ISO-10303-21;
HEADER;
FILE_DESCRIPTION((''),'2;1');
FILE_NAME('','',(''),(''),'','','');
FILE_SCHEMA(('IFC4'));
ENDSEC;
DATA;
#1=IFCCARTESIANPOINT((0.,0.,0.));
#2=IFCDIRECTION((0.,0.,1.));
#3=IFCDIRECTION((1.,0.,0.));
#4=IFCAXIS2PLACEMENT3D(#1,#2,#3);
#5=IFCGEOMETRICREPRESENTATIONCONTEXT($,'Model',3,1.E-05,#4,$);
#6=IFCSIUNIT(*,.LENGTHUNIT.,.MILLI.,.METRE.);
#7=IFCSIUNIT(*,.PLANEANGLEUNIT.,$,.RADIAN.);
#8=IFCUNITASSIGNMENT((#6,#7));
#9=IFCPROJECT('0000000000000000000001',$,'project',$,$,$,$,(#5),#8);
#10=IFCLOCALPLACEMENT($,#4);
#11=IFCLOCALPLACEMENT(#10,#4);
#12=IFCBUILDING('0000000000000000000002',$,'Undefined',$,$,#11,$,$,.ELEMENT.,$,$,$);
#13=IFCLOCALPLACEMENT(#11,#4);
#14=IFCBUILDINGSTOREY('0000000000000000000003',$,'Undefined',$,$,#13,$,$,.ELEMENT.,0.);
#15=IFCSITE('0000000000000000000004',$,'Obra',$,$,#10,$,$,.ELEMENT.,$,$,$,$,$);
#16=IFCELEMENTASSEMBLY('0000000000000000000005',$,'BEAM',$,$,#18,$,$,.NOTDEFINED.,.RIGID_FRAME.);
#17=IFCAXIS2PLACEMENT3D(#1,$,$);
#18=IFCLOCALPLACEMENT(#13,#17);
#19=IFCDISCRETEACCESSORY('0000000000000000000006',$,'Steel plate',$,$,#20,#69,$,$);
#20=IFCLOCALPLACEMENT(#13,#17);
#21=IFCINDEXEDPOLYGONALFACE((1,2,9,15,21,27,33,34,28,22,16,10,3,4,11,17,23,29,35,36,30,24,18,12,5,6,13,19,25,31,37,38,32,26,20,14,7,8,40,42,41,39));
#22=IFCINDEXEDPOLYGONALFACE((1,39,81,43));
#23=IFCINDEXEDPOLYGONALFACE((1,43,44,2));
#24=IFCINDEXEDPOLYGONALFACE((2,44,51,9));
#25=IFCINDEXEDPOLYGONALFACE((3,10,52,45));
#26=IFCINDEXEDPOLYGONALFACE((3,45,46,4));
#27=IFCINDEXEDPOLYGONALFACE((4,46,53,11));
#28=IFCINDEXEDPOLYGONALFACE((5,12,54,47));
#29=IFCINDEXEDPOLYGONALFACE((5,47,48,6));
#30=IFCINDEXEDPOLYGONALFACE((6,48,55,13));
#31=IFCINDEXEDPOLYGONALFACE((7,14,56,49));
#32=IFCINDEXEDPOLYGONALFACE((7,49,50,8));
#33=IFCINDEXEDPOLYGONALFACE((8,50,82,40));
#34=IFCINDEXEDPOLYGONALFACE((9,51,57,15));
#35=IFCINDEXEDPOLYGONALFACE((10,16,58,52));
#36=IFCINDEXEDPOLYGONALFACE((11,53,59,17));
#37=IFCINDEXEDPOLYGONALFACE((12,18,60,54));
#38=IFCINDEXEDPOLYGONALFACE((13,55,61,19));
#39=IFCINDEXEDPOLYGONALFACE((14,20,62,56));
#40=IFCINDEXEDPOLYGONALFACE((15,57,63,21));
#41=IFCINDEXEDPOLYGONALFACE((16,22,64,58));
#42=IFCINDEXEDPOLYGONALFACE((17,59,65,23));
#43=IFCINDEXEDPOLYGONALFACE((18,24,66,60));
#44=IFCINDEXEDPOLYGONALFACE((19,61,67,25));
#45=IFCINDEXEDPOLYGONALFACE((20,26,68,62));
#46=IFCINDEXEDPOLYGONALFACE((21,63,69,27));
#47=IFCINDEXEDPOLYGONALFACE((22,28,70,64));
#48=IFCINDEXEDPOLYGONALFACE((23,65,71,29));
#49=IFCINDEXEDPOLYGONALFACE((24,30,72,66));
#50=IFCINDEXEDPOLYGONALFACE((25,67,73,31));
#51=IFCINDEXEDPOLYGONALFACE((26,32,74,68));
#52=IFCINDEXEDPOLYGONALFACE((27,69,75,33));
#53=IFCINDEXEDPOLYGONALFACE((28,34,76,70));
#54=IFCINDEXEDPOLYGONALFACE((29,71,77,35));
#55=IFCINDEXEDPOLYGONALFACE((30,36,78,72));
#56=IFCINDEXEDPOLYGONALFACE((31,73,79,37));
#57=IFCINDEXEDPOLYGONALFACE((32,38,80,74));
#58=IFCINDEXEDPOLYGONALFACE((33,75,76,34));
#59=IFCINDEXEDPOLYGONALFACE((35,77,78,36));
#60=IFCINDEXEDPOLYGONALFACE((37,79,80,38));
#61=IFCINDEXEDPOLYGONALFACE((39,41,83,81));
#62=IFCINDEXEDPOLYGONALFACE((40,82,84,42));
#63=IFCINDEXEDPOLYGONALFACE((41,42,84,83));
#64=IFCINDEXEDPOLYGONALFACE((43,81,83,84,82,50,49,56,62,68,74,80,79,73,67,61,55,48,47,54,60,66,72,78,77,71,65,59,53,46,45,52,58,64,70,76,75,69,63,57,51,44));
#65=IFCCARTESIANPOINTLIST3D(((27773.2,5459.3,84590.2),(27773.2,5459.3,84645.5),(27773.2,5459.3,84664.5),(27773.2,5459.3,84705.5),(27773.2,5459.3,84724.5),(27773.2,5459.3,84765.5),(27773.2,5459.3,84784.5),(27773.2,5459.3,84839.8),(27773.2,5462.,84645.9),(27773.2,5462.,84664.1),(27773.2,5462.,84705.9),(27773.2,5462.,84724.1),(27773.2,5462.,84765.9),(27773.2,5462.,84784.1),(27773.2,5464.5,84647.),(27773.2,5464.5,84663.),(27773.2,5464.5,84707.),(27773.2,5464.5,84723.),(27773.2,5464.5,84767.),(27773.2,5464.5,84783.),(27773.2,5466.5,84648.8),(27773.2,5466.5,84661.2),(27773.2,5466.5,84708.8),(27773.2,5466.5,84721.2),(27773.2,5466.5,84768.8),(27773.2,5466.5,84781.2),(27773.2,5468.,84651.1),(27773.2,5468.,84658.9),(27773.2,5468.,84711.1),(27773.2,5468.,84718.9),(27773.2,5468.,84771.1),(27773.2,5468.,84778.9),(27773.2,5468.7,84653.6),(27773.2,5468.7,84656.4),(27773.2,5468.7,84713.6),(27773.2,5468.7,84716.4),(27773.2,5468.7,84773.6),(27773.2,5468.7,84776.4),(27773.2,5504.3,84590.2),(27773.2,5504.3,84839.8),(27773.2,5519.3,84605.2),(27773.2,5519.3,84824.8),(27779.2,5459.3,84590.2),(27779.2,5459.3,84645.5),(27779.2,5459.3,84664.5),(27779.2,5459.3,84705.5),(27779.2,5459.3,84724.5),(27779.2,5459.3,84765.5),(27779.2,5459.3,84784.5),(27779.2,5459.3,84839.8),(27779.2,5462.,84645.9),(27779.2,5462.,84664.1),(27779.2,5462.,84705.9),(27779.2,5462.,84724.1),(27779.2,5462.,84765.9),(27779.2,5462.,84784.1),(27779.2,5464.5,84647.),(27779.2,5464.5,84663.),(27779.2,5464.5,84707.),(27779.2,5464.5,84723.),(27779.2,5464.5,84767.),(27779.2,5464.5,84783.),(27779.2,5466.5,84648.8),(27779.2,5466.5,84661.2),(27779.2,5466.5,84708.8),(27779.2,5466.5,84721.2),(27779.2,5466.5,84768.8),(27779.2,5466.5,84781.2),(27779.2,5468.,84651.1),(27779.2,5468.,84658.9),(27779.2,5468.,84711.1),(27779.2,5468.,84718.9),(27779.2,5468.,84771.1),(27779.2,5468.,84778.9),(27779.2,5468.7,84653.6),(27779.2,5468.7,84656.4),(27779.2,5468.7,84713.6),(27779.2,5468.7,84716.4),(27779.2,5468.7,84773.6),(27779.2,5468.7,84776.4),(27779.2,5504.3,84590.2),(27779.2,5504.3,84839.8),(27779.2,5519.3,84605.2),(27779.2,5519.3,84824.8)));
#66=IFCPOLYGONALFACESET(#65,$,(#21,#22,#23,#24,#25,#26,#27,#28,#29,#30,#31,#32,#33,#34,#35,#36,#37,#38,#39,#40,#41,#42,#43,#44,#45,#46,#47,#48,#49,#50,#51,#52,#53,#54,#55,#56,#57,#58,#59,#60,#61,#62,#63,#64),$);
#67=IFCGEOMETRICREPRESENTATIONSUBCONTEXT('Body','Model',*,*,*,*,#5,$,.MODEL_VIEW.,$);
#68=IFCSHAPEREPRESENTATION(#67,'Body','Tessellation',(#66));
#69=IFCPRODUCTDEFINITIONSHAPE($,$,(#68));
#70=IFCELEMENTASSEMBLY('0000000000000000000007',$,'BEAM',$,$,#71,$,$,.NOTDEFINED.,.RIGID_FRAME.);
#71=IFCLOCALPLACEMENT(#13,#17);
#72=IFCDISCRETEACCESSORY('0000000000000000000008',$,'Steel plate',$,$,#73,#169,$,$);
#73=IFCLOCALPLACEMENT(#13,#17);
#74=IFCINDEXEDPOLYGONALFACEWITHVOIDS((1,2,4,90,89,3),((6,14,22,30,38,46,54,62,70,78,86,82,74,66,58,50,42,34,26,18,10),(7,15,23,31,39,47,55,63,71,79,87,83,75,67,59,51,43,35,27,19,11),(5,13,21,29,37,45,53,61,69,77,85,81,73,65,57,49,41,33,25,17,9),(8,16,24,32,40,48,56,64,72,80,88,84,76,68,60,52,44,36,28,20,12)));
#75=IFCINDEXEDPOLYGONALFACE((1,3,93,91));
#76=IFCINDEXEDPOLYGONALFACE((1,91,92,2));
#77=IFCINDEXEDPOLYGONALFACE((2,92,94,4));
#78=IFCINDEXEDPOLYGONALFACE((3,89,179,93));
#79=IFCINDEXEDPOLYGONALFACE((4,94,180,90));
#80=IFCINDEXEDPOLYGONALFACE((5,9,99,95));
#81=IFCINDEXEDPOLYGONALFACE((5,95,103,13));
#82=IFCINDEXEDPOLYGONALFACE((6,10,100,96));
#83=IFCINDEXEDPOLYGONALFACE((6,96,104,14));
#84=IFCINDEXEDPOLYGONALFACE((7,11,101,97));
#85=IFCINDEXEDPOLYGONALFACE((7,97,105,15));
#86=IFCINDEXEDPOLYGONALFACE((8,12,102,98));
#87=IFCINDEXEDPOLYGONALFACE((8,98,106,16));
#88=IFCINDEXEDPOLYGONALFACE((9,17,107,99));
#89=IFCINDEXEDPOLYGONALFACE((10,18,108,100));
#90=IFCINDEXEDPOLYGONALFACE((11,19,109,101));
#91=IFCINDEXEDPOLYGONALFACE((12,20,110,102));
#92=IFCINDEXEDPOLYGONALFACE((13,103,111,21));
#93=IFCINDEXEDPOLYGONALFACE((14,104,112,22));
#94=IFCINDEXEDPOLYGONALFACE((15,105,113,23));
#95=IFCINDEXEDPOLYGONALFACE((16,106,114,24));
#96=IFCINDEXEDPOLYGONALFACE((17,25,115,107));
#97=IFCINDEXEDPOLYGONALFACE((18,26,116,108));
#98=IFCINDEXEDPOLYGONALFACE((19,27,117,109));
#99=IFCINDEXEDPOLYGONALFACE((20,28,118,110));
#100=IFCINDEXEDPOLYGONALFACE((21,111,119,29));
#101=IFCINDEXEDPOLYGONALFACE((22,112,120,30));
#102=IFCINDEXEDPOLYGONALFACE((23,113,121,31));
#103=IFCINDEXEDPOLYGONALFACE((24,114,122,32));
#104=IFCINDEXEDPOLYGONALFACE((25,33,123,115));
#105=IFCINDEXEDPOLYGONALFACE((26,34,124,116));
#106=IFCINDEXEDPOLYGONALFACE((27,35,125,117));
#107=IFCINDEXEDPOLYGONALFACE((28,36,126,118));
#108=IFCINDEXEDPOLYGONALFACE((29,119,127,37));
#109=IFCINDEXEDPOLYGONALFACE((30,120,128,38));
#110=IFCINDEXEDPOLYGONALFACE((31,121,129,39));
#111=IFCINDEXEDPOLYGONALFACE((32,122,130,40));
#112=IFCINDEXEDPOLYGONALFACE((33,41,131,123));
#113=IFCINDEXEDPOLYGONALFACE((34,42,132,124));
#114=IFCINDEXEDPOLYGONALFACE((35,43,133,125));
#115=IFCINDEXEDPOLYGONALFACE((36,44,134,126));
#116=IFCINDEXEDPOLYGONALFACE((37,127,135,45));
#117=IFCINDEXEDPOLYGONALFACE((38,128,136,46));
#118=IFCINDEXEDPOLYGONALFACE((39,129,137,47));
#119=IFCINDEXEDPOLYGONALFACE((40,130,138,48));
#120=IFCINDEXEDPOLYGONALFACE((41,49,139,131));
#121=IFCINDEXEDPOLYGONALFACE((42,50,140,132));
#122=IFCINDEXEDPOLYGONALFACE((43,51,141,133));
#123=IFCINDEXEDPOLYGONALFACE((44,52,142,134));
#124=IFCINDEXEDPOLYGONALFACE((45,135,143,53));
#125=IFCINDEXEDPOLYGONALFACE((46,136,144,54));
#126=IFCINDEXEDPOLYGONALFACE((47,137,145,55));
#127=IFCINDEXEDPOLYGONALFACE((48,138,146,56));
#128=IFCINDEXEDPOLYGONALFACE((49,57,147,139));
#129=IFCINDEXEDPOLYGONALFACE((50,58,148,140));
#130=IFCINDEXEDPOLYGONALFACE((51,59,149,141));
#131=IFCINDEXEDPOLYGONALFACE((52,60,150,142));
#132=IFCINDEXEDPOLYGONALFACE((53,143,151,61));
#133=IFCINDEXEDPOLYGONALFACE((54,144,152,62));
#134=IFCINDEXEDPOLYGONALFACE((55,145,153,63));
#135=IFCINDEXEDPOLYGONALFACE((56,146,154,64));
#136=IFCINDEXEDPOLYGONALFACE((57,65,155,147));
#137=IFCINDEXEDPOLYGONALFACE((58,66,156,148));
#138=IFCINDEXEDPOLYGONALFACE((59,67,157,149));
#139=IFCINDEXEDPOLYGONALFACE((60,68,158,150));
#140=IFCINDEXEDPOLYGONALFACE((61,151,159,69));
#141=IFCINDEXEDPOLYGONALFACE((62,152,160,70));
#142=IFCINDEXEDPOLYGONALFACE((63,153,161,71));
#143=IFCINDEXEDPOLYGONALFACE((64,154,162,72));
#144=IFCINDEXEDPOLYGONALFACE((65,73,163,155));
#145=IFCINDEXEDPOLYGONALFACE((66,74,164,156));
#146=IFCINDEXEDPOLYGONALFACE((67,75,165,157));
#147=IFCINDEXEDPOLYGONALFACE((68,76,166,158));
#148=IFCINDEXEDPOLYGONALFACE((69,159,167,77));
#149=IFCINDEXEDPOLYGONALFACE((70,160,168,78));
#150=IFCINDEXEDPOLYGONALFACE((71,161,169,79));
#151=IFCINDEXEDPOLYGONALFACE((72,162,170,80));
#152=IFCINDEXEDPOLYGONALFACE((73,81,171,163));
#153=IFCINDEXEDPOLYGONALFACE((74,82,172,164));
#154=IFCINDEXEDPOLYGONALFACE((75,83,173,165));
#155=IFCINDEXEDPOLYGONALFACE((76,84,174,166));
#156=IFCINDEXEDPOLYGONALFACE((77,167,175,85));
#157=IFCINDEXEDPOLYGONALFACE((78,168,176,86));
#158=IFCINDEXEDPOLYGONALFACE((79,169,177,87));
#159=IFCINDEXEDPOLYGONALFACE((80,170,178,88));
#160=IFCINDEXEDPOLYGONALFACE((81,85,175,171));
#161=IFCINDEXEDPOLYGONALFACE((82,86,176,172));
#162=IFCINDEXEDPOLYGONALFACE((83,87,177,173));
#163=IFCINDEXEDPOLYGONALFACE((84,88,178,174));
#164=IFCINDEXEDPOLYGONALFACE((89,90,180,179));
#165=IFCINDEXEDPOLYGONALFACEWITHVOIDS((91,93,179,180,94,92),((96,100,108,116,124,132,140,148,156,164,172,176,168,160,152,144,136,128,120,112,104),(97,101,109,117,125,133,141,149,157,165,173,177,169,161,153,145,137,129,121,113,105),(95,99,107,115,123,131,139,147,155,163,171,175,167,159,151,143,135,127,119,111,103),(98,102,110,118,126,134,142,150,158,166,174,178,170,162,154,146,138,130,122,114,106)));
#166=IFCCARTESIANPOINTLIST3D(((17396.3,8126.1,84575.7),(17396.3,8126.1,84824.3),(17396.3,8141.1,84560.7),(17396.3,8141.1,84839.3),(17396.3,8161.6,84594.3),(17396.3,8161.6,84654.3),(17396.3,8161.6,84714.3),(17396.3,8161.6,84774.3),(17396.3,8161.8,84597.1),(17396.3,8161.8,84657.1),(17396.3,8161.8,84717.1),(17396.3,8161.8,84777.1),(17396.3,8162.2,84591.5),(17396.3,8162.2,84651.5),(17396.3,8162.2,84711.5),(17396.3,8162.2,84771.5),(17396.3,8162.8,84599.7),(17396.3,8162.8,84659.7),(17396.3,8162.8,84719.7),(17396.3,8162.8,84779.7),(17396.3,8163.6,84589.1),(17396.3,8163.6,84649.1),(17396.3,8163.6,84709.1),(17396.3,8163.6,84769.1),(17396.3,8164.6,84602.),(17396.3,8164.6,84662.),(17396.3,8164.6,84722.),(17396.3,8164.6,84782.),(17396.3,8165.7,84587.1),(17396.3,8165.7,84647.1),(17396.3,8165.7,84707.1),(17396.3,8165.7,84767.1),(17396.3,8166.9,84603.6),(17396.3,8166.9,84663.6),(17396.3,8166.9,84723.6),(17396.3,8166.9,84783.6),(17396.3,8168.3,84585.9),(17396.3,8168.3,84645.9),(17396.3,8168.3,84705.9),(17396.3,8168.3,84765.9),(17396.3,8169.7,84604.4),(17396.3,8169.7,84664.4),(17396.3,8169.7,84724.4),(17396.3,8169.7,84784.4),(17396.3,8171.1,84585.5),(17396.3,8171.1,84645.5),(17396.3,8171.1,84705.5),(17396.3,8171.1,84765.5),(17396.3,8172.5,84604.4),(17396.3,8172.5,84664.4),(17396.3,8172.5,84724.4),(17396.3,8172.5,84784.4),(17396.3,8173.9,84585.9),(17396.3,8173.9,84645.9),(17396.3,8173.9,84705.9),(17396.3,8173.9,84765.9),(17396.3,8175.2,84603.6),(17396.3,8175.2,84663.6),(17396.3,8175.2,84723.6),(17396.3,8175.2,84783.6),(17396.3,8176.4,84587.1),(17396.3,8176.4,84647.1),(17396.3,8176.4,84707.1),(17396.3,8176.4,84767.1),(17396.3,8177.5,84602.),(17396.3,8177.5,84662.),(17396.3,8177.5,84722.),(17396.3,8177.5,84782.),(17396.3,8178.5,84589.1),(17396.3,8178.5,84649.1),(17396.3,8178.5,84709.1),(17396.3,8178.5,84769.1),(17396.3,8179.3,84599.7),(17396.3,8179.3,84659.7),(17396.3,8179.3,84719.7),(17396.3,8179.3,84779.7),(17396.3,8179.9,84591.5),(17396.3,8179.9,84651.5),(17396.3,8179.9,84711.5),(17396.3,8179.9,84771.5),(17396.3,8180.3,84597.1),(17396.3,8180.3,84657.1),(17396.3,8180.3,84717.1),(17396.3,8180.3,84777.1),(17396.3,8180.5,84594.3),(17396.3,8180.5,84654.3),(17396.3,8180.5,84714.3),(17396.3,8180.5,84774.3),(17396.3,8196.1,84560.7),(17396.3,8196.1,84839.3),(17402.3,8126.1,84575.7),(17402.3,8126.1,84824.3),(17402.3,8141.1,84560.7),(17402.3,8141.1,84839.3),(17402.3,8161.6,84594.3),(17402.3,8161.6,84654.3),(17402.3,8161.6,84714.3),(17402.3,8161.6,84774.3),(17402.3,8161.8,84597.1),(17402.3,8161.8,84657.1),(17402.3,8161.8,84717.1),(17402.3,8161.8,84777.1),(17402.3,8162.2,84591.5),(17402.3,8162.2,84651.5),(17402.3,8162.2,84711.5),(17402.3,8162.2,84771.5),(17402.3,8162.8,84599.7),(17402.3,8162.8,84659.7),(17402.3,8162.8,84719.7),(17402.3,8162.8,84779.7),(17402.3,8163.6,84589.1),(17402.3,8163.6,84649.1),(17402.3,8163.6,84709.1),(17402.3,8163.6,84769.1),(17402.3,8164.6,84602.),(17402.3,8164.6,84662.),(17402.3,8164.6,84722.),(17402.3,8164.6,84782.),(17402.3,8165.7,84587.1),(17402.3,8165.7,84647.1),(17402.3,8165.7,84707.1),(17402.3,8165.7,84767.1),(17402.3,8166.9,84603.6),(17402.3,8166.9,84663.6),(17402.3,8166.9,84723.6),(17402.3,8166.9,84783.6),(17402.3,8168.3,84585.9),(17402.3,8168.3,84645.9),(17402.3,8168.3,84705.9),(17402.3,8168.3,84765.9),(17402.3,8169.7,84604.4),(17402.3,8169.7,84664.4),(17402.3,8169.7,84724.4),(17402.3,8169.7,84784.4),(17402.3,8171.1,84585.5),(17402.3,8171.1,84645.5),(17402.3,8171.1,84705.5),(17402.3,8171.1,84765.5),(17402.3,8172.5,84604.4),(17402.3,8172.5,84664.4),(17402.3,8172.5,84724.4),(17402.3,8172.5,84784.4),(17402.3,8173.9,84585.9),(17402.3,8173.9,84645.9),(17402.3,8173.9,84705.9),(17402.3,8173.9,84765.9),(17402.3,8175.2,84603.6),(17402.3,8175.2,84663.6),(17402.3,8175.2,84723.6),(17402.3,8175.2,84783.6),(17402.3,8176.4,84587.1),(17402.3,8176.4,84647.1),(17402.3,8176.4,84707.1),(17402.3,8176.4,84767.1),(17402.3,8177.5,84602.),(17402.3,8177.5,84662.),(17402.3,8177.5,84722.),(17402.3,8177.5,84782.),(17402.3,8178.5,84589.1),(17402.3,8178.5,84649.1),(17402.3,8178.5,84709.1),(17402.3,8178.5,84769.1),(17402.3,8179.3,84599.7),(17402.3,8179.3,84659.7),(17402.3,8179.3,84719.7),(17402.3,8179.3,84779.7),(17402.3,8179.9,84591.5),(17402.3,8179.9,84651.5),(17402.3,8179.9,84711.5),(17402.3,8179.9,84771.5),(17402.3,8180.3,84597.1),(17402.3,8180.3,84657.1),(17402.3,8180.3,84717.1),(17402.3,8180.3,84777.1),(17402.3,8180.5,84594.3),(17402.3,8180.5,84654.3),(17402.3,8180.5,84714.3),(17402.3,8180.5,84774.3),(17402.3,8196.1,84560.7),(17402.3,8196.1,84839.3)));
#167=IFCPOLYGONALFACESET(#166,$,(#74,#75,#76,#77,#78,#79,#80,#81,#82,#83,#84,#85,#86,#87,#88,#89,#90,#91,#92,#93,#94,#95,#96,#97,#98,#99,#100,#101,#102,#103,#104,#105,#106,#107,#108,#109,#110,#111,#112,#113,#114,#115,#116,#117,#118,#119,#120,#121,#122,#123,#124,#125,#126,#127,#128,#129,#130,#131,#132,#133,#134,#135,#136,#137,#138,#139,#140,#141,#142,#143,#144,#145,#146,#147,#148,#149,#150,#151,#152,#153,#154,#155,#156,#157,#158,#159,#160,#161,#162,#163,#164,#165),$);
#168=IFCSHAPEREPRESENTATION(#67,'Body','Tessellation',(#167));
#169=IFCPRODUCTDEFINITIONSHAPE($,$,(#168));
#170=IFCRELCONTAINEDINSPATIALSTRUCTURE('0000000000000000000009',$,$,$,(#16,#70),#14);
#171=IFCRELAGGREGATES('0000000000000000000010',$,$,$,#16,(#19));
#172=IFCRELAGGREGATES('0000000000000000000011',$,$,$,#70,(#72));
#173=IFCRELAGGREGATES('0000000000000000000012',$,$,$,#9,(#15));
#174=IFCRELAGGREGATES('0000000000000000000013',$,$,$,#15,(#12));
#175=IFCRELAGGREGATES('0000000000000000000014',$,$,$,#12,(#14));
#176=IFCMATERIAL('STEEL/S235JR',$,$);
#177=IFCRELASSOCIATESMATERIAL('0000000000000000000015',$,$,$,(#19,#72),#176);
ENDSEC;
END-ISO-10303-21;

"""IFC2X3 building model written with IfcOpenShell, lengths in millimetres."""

from ifc_helpers import new_model, si_unit, frame, origin_with_axes, origin_2d_with_axis, place, context, subcontext, project, spatial, polyline, circle, outline, extrude, source, transform, mapped, material, element, aggregate, save


model = new_model("IFC2X3")

# Units and contexts
model_context = context("Model", 3, precision=1e-05, world=origin_with_axes())
body_context = subcontext(model_context, "Body", "Model", "MODEL_VIEW")
ifc_project = project(units=[si_unit("LENGTHUNIT", "METRE", prefix="MILLI"), si_unit("PLANEANGLEUNIT", "RADIAN")], contexts=[model_context])

# Site, building, storey
site_placement = place(None, origin_with_axes())
site = spatial("IfcSite", under=ifc_project, at=site_placement, Name="Obra", CompositionType="ELEMENT")
building_placement = place(site_placement, origin_with_axes())
building = spatial("IfcBuilding", under=site, at=building_placement, Name="Undefined", CompositionType="ELEMENT")
storey_placement = place(building_placement, origin_with_axes())
storey = spatial("IfcBuildingStorey", under=building, at=storey_placement, Name="Undefined", CompositionType="ELEMENT", Elevation=0.0)

# Shared definitions
ifc_material_1 = material(Name="STEEL/S235JR")

# Element assembly
assembly_1_placement = place(storey_placement, origin_with_axes())
assembly_1 = element("IfcElementAssembly", 1, at=assembly_1_placement, inside=storey, Name="BEAM", AssemblyPlace="NOTDEFINED", PredefinedType="RIGID_FRAME")
shared_shape_1 = source(origin_with_axes(), body_context, "Body", "SweptSolid", [
    extrude(circle(Radius=9.5, at=origin_2d_with_axis()), frame((0.0, -9.4, 0.0), z_axis=(0.0, 1.0, 0.0), x_axis=(1.0, 0.0, 0.0)), (0.0, 0.0, 1.0), 6.2),
])

# Discrete accessory, opening
discrete_accessory_1_placement = place(assembly_1_placement, frame((27776.2, 5459.3, 84590.2), z_axis=(1.0, 0.000001, 0.0), x_axis=(-0.000002, 1.0, 0.0)))
discrete_accessory_1 = element("IfcDiscreteAccessory", 2, at=discrete_accessory_1_placement, material=ifc_material_1, Name="Steel plate", context=body_context, shape_type="SweptSolid", body=[
    extrude(outline(polyline([(0.0, 0.0), (45.0, 0.0), (60.0, 15.0), (60.0, 234.6), (45.0, 249.6), (0.0, 249.6), (0.0, 0.0)])), frame((0.0, 0.0, -3.0), z_axis=(0.0, 0.0, 1.0), x_axis=(1.0, 0.0, 0.0)), (0.0, 0.0, 1.0), 6.0),
])
opening_1_placement = place(assembly_1_placement, frame((27782.5, 5509.3, 84850.0), z_axis=(0.000002, -1.0, 0.0), x_axis=(0.0, 0.0, -1.0)))
element("IfcOpeningElement", 3, at=opening_1_placement, cuts=discrete_accessory_1, ObjectType="Opening", context=body_context, shape_type="MappedRepresentation", body=[
    mapped(shared_shape_1, transform((75.0, 0.0, 50.0))),
    mapped(shared_shape_1, transform((135.0, 0.0, 50.0))),
    mapped(shared_shape_1, transform((195.0, 0.0, 50.0))),
])
aggregate(assembly_1, [discrete_accessory_1])

# Element assembly, discrete accessory, opening
assembly_2_placement = place(storey_placement, origin_with_axes())
assembly_2 = element("IfcElementAssembly", 4, at=assembly_2_placement, inside=storey, Name="BEAM", AssemblyPlace="NOTDEFINED", PredefinedType="RIGID_FRAME")
discrete_accessory_2_placement = place(assembly_2_placement, frame((17399.3, 8196.1, 84560.7), z_axis=(-1.0, 0.0, 0.0), x_axis=(0.0, -1.0, 0.0)))
discrete_accessory_2 = element("IfcDiscreteAccessory", 5, at=discrete_accessory_2_placement, material=ifc_material_1, Name="Steel plate", context=body_context, shape_type="SweptSolid", body=[
    extrude(outline(polyline([(0.0, 0.0), (55.0, 0.0), (70.0, 15.0), (70.0, 263.6), (55.0, 278.6), (0.0, 278.6), (0.0, 0.0)])), frame((0.0, 0.0, -3.0), z_axis=(0.0, 0.0, 1.0), x_axis=(1.0, 0.0, 0.0)), (0.0, 0.0, 1.0), 6.0),
])
shared_shape_2 = source(origin_with_axes(), body_context, "Body", "SweptSolid", [
    extrude(circle(Radius=9.5, at=origin_2d_with_axis()), frame((0.0, -9.8, 0.0), z_axis=(0.0, 1.0, 0.0), x_axis=(1.0, 0.0, 0.0)), (0.0, 0.0, 1.0), 6.2),
])
opening_2_placement = place(assembly_2_placement, frame((17392.6, 8136.1, 84850.0), z_axis=(0.0, 1.0, 0.0), x_axis=(0.0, 0.0, -1.0)))
element("IfcOpeningElement", 6, at=opening_2_placement, cuts=discrete_accessory_2, ObjectType="Opening", context=body_context, shape_type="MappedRepresentation", body=[
    mapped(shared_shape_2, transform((75.0, 0.0, 35.0))),
    mapped(shared_shape_2, transform((135.0, 0.0, 35.0))),
    mapped(shared_shape_2, transform((195.0, 0.0, 35.0))),
    mapped(shared_shape_2, transform((255.0, 0.0, 35.0))),
])
aggregate(assembly_2, [discrete_accessory_2])

save(model, "model.ifc")
